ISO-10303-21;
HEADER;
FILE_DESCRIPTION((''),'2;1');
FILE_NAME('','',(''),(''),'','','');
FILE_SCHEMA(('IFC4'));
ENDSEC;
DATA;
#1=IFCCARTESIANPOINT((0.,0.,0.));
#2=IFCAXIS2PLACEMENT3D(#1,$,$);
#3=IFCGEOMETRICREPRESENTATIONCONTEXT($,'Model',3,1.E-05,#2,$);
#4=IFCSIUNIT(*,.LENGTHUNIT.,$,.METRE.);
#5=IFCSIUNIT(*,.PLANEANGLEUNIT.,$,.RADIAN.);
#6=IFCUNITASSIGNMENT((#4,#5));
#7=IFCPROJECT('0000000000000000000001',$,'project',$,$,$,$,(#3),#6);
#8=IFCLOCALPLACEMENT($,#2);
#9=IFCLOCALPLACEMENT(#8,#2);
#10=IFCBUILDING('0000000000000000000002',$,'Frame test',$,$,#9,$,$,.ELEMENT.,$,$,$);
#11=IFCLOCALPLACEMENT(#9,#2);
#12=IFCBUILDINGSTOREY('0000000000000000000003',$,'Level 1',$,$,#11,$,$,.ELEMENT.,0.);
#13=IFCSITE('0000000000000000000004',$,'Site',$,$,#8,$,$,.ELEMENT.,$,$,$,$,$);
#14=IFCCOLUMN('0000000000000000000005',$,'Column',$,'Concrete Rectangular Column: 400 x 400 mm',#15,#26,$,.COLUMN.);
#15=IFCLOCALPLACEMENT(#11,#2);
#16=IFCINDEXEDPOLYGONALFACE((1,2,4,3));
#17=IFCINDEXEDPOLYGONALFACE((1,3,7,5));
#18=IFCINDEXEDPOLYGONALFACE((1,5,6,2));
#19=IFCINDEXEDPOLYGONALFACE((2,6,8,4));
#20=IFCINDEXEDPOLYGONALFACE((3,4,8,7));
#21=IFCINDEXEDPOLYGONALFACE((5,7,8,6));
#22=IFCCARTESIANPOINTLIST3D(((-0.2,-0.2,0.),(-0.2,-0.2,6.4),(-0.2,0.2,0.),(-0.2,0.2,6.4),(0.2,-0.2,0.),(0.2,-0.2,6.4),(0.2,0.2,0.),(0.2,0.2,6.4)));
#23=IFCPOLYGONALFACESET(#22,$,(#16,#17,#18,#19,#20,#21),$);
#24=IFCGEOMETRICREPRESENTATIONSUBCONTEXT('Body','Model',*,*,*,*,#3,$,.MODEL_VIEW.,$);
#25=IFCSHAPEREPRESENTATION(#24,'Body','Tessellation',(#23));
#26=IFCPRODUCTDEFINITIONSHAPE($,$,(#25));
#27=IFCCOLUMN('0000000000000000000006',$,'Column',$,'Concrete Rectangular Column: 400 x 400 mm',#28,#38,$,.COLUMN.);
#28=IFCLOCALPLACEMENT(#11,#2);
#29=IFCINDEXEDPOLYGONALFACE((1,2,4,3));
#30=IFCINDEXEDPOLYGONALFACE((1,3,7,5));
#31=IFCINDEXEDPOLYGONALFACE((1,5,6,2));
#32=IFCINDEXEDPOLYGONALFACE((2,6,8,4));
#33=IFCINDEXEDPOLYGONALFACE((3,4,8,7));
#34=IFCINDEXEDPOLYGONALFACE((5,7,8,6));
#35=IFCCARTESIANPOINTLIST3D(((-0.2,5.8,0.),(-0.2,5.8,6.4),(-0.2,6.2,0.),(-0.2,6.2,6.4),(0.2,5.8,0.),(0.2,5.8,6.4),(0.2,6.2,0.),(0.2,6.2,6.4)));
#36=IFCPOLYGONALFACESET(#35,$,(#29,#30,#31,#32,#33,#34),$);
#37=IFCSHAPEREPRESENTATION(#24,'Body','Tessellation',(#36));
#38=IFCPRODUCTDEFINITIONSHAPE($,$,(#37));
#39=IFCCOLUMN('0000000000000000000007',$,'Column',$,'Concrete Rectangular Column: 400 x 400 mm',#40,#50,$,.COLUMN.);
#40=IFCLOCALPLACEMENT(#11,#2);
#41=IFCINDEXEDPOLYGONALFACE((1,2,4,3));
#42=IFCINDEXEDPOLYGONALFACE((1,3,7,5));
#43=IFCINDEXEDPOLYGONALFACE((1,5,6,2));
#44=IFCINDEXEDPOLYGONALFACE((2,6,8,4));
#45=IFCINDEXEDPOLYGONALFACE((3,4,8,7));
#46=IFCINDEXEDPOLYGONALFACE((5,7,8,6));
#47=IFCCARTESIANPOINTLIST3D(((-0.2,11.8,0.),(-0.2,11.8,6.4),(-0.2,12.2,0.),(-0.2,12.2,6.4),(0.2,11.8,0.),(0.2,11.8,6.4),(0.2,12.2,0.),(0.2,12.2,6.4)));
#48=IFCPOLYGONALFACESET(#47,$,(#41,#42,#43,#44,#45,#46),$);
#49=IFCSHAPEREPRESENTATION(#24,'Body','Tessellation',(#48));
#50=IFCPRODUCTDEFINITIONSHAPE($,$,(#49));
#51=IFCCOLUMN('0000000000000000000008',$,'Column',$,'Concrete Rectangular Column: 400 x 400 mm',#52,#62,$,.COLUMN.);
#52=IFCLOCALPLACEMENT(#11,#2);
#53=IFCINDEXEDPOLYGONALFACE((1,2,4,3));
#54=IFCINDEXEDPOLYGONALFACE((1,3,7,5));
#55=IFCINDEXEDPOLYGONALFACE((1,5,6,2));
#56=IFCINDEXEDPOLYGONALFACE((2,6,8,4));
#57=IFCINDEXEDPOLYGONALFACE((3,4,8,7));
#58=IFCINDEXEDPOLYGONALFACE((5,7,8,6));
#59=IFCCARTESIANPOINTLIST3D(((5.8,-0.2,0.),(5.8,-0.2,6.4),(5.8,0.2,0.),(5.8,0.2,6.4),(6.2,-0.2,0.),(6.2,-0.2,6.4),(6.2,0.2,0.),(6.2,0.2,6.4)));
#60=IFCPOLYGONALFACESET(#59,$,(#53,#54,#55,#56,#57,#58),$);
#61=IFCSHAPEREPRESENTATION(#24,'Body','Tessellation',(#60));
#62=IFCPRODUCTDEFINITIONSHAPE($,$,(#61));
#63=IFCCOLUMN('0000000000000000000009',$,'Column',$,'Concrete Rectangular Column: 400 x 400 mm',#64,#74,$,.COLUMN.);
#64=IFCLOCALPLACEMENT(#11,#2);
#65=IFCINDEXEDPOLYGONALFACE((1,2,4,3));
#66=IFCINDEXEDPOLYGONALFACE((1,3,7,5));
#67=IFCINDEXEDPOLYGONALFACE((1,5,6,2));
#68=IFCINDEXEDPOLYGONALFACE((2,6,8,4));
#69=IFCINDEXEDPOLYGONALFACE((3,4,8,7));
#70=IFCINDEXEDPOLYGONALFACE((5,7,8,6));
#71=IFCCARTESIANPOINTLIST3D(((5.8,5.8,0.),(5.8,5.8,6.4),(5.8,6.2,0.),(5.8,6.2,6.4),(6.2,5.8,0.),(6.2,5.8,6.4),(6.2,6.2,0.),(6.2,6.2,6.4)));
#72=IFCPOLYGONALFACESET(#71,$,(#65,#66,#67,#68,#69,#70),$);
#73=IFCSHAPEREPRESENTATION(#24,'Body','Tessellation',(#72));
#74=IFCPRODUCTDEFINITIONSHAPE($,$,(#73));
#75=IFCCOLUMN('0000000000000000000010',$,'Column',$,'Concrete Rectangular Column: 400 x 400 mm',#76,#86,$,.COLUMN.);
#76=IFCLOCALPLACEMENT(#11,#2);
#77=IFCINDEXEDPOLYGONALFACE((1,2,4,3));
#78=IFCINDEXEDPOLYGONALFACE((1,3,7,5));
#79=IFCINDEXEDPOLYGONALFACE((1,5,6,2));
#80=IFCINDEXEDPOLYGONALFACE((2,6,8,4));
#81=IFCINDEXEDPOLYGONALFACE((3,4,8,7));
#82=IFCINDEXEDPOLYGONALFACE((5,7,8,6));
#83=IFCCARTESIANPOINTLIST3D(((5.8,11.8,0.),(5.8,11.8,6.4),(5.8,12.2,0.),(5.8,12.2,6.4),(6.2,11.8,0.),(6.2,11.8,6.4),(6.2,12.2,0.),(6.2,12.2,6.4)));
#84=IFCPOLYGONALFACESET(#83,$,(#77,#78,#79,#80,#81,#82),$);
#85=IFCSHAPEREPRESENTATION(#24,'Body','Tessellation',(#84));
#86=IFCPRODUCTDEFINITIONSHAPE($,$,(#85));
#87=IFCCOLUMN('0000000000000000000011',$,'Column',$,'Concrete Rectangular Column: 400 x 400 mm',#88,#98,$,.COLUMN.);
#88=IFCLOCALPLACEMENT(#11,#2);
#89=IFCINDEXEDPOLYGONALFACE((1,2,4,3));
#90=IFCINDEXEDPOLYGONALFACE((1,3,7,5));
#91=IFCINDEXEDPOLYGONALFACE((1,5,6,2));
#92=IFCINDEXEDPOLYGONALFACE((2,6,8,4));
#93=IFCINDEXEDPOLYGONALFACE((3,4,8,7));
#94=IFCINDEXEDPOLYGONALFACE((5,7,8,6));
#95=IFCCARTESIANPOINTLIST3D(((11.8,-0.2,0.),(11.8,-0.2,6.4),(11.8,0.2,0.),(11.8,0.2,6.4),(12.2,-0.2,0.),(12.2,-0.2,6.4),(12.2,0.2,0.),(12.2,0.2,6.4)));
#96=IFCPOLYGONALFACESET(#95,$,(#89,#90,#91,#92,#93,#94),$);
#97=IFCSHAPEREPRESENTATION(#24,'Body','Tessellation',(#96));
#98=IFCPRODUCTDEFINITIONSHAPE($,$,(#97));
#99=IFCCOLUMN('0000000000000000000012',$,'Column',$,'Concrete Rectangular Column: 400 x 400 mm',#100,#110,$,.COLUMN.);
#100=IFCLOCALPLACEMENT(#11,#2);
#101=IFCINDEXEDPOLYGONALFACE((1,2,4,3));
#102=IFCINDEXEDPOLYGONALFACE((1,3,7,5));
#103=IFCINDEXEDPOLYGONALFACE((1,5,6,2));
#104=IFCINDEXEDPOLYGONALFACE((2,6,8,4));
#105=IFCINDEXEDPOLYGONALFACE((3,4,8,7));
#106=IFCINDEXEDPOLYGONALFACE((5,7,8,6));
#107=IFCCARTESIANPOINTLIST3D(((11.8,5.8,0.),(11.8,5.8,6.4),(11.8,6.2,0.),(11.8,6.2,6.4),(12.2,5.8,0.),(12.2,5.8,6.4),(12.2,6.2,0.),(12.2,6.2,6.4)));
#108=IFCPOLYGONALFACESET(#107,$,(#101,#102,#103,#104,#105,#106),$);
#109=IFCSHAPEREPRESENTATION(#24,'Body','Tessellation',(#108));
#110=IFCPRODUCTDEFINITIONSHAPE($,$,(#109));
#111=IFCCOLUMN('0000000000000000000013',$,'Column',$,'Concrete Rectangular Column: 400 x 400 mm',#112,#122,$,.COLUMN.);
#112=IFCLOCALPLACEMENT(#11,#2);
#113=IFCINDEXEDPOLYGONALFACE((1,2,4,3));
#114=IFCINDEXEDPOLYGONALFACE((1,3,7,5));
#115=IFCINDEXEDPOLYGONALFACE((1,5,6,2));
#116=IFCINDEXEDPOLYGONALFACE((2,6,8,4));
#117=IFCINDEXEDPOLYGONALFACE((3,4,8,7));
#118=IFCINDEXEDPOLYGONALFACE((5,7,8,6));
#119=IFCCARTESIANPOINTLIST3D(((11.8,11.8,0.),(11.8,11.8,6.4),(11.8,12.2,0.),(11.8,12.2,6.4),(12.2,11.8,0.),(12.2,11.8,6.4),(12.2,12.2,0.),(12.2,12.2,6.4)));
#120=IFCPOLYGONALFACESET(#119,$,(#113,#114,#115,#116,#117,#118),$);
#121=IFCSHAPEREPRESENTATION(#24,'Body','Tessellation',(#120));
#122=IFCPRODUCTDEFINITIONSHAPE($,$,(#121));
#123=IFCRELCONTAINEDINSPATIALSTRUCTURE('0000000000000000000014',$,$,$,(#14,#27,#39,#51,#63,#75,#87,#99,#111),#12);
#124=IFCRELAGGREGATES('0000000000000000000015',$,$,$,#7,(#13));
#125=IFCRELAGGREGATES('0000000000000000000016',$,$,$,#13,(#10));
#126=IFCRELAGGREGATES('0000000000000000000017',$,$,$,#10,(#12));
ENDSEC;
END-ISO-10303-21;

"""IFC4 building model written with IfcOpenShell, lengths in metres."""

from ifc_helpers import new_model, si_unit, origin, place, context, subcontext, project, spatial, polyline, outline, extrude, element, save


model = new_model("IFC4")

# Units and contexts
model_context = context("Model", 3, precision=1e-05, world=origin())
body_context = subcontext(model_context, "Body", "Model", "MODEL_VIEW")
ifc_project = project(units=[si_unit("LENGTHUNIT", "METRE"), si_unit("PLANEANGLEUNIT", "RADIAN")], contexts=[model_context])

# Site, building, storey
site_placement = place(None, origin())
site = spatial("IfcSite", under=ifc_project, at=site_placement, Name="Site", CompositionType="ELEMENT")
building_placement = place(site_placement, origin())
building = spatial("IfcBuilding", under=site, at=building_placement, Name="Frame test", CompositionType="ELEMENT")
storey_placement = place(building_placement, origin())
storey = spatial("IfcBuildingStorey", under=building, at=storey_placement, Name="Level 1", CompositionType="ELEMENT", Elevation=0.0)

# Columns
column_1_placement = place(storey_placement, origin())
element("IfcColumn", 1, at=column_1_placement, inside=storey, Name="Column", ObjectType="Concrete Rectangular Column: 400 x 400 mm", PredefinedType="COLUMN", context=body_context, shape_type="SweptSolid", body=[
    extrude(outline(polyline([(-0.2, -0.2), (0.2, -0.2), (0.2, 0.2), (-0.2, 0.2), (-0.2, -0.2)])), origin(), (0.0, 0.0, 1.0), 6.4),
])
column_2_placement = place(storey_placement, origin())
element("IfcColumn", 2, at=column_2_placement, inside=storey, Name="Column", ObjectType="Concrete Rectangular Column: 400 x 400 mm", PredefinedType="COLUMN", context=body_context, shape_type="SweptSolid", body=[
    extrude(outline(polyline([(-0.2, 5.8), (0.2, 5.8), (0.2, 6.2), (-0.2, 6.2), (-0.2, 5.8)])), origin(), (0.0, 0.0, 1.0), 6.4),
])
column_3_placement = place(storey_placement, origin())
element("IfcColumn", 3, at=column_3_placement, inside=storey, Name="Column", ObjectType="Concrete Rectangular Column: 400 x 400 mm", PredefinedType="COLUMN", context=body_context, shape_type="SweptSolid", body=[
    extrude(outline(polyline([(-0.2, 11.8), (0.2, 11.8), (0.2, 12.2), (-0.2, 12.2), (-0.2, 11.8)])), origin(), (0.0, 0.0, 1.0), 6.4),
])
column_4_placement = place(storey_placement, origin())
element("IfcColumn", 4, at=column_4_placement, inside=storey, Name="Column", ObjectType="Concrete Rectangular Column: 400 x 400 mm", PredefinedType="COLUMN", context=body_context, shape_type="SweptSolid", body=[
    extrude(outline(polyline([(5.8, -0.2), (6.2, -0.2), (6.2, 0.2), (5.8, 0.2), (5.8, -0.2)])), origin(), (0.0, 0.0, 1.0), 6.4),
])
column_5_placement = place(storey_placement, origin())
element("IfcColumn", 5, at=column_5_placement, inside=storey, Name="Column", ObjectType="Concrete Rectangular Column: 400 x 400 mm", PredefinedType="COLUMN", context=body_context, shape_type="SweptSolid", body=[
    extrude(outline(polyline([(5.8, 5.8), (6.2, 5.8), (6.2, 6.2), (5.8, 6.2), (5.8, 5.8)])), origin(), (0.0, 0.0, 1.0), 6.4),
])
column_6_placement = place(storey_placement, origin())
element("IfcColumn", 6, at=column_6_placement, inside=storey, Name="Column", ObjectType="Concrete Rectangular Column: 400 x 400 mm", PredefinedType="COLUMN", context=body_context, shape_type="SweptSolid", body=[
    extrude(outline(polyline([(5.8, 11.8), (6.2, 11.8), (6.2, 12.2), (5.8, 12.2), (5.8, 11.8)])), origin(), (0.0, 0.0, 1.0), 6.4),
])
column_7_placement = place(storey_placement, origin())
element("IfcColumn", 7, at=column_7_placement, inside=storey, Name="Column", ObjectType="Concrete Rectangular Column: 400 x 400 mm", PredefinedType="COLUMN", context=body_context, shape_type="SweptSolid", body=[
    extrude(outline(polyline([(11.8, -0.2), (12.2, -0.2), (12.2, 0.2), (11.8, 0.2), (11.8, -0.2)])), origin(), (0.0, 0.0, 1.0), 6.4),
])
column_8_placement = place(storey_placement, origin())
element("IfcColumn", 8, at=column_8_placement, inside=storey, Name="Column", ObjectType="Concrete Rectangular Column: 400 x 400 mm", PredefinedType="COLUMN", context=body_context, shape_type="SweptSolid", body=[
    extrude(outline(polyline([(11.8, 5.8), (12.2, 5.8), (12.2, 6.2), (11.8, 6.2), (11.8, 5.8)])), origin(), (0.0, 0.0, 1.0), 6.4),
])
column_9_placement = place(storey_placement, origin())
element("IfcColumn", 9, at=column_9_placement, inside=storey, Name="Column", ObjectType="Concrete Rectangular Column: 400 x 400 mm", PredefinedType="COLUMN", context=body_context, shape_type="SweptSolid", body=[
    extrude(outline(polyline([(11.8, 11.8), (12.2, 11.8), (12.2, 12.2), (11.8, 12.2), (11.8, 11.8)])), origin(), (0.0, 0.0, 1.0), 6.4),
])

save(model, "model.ifc")
